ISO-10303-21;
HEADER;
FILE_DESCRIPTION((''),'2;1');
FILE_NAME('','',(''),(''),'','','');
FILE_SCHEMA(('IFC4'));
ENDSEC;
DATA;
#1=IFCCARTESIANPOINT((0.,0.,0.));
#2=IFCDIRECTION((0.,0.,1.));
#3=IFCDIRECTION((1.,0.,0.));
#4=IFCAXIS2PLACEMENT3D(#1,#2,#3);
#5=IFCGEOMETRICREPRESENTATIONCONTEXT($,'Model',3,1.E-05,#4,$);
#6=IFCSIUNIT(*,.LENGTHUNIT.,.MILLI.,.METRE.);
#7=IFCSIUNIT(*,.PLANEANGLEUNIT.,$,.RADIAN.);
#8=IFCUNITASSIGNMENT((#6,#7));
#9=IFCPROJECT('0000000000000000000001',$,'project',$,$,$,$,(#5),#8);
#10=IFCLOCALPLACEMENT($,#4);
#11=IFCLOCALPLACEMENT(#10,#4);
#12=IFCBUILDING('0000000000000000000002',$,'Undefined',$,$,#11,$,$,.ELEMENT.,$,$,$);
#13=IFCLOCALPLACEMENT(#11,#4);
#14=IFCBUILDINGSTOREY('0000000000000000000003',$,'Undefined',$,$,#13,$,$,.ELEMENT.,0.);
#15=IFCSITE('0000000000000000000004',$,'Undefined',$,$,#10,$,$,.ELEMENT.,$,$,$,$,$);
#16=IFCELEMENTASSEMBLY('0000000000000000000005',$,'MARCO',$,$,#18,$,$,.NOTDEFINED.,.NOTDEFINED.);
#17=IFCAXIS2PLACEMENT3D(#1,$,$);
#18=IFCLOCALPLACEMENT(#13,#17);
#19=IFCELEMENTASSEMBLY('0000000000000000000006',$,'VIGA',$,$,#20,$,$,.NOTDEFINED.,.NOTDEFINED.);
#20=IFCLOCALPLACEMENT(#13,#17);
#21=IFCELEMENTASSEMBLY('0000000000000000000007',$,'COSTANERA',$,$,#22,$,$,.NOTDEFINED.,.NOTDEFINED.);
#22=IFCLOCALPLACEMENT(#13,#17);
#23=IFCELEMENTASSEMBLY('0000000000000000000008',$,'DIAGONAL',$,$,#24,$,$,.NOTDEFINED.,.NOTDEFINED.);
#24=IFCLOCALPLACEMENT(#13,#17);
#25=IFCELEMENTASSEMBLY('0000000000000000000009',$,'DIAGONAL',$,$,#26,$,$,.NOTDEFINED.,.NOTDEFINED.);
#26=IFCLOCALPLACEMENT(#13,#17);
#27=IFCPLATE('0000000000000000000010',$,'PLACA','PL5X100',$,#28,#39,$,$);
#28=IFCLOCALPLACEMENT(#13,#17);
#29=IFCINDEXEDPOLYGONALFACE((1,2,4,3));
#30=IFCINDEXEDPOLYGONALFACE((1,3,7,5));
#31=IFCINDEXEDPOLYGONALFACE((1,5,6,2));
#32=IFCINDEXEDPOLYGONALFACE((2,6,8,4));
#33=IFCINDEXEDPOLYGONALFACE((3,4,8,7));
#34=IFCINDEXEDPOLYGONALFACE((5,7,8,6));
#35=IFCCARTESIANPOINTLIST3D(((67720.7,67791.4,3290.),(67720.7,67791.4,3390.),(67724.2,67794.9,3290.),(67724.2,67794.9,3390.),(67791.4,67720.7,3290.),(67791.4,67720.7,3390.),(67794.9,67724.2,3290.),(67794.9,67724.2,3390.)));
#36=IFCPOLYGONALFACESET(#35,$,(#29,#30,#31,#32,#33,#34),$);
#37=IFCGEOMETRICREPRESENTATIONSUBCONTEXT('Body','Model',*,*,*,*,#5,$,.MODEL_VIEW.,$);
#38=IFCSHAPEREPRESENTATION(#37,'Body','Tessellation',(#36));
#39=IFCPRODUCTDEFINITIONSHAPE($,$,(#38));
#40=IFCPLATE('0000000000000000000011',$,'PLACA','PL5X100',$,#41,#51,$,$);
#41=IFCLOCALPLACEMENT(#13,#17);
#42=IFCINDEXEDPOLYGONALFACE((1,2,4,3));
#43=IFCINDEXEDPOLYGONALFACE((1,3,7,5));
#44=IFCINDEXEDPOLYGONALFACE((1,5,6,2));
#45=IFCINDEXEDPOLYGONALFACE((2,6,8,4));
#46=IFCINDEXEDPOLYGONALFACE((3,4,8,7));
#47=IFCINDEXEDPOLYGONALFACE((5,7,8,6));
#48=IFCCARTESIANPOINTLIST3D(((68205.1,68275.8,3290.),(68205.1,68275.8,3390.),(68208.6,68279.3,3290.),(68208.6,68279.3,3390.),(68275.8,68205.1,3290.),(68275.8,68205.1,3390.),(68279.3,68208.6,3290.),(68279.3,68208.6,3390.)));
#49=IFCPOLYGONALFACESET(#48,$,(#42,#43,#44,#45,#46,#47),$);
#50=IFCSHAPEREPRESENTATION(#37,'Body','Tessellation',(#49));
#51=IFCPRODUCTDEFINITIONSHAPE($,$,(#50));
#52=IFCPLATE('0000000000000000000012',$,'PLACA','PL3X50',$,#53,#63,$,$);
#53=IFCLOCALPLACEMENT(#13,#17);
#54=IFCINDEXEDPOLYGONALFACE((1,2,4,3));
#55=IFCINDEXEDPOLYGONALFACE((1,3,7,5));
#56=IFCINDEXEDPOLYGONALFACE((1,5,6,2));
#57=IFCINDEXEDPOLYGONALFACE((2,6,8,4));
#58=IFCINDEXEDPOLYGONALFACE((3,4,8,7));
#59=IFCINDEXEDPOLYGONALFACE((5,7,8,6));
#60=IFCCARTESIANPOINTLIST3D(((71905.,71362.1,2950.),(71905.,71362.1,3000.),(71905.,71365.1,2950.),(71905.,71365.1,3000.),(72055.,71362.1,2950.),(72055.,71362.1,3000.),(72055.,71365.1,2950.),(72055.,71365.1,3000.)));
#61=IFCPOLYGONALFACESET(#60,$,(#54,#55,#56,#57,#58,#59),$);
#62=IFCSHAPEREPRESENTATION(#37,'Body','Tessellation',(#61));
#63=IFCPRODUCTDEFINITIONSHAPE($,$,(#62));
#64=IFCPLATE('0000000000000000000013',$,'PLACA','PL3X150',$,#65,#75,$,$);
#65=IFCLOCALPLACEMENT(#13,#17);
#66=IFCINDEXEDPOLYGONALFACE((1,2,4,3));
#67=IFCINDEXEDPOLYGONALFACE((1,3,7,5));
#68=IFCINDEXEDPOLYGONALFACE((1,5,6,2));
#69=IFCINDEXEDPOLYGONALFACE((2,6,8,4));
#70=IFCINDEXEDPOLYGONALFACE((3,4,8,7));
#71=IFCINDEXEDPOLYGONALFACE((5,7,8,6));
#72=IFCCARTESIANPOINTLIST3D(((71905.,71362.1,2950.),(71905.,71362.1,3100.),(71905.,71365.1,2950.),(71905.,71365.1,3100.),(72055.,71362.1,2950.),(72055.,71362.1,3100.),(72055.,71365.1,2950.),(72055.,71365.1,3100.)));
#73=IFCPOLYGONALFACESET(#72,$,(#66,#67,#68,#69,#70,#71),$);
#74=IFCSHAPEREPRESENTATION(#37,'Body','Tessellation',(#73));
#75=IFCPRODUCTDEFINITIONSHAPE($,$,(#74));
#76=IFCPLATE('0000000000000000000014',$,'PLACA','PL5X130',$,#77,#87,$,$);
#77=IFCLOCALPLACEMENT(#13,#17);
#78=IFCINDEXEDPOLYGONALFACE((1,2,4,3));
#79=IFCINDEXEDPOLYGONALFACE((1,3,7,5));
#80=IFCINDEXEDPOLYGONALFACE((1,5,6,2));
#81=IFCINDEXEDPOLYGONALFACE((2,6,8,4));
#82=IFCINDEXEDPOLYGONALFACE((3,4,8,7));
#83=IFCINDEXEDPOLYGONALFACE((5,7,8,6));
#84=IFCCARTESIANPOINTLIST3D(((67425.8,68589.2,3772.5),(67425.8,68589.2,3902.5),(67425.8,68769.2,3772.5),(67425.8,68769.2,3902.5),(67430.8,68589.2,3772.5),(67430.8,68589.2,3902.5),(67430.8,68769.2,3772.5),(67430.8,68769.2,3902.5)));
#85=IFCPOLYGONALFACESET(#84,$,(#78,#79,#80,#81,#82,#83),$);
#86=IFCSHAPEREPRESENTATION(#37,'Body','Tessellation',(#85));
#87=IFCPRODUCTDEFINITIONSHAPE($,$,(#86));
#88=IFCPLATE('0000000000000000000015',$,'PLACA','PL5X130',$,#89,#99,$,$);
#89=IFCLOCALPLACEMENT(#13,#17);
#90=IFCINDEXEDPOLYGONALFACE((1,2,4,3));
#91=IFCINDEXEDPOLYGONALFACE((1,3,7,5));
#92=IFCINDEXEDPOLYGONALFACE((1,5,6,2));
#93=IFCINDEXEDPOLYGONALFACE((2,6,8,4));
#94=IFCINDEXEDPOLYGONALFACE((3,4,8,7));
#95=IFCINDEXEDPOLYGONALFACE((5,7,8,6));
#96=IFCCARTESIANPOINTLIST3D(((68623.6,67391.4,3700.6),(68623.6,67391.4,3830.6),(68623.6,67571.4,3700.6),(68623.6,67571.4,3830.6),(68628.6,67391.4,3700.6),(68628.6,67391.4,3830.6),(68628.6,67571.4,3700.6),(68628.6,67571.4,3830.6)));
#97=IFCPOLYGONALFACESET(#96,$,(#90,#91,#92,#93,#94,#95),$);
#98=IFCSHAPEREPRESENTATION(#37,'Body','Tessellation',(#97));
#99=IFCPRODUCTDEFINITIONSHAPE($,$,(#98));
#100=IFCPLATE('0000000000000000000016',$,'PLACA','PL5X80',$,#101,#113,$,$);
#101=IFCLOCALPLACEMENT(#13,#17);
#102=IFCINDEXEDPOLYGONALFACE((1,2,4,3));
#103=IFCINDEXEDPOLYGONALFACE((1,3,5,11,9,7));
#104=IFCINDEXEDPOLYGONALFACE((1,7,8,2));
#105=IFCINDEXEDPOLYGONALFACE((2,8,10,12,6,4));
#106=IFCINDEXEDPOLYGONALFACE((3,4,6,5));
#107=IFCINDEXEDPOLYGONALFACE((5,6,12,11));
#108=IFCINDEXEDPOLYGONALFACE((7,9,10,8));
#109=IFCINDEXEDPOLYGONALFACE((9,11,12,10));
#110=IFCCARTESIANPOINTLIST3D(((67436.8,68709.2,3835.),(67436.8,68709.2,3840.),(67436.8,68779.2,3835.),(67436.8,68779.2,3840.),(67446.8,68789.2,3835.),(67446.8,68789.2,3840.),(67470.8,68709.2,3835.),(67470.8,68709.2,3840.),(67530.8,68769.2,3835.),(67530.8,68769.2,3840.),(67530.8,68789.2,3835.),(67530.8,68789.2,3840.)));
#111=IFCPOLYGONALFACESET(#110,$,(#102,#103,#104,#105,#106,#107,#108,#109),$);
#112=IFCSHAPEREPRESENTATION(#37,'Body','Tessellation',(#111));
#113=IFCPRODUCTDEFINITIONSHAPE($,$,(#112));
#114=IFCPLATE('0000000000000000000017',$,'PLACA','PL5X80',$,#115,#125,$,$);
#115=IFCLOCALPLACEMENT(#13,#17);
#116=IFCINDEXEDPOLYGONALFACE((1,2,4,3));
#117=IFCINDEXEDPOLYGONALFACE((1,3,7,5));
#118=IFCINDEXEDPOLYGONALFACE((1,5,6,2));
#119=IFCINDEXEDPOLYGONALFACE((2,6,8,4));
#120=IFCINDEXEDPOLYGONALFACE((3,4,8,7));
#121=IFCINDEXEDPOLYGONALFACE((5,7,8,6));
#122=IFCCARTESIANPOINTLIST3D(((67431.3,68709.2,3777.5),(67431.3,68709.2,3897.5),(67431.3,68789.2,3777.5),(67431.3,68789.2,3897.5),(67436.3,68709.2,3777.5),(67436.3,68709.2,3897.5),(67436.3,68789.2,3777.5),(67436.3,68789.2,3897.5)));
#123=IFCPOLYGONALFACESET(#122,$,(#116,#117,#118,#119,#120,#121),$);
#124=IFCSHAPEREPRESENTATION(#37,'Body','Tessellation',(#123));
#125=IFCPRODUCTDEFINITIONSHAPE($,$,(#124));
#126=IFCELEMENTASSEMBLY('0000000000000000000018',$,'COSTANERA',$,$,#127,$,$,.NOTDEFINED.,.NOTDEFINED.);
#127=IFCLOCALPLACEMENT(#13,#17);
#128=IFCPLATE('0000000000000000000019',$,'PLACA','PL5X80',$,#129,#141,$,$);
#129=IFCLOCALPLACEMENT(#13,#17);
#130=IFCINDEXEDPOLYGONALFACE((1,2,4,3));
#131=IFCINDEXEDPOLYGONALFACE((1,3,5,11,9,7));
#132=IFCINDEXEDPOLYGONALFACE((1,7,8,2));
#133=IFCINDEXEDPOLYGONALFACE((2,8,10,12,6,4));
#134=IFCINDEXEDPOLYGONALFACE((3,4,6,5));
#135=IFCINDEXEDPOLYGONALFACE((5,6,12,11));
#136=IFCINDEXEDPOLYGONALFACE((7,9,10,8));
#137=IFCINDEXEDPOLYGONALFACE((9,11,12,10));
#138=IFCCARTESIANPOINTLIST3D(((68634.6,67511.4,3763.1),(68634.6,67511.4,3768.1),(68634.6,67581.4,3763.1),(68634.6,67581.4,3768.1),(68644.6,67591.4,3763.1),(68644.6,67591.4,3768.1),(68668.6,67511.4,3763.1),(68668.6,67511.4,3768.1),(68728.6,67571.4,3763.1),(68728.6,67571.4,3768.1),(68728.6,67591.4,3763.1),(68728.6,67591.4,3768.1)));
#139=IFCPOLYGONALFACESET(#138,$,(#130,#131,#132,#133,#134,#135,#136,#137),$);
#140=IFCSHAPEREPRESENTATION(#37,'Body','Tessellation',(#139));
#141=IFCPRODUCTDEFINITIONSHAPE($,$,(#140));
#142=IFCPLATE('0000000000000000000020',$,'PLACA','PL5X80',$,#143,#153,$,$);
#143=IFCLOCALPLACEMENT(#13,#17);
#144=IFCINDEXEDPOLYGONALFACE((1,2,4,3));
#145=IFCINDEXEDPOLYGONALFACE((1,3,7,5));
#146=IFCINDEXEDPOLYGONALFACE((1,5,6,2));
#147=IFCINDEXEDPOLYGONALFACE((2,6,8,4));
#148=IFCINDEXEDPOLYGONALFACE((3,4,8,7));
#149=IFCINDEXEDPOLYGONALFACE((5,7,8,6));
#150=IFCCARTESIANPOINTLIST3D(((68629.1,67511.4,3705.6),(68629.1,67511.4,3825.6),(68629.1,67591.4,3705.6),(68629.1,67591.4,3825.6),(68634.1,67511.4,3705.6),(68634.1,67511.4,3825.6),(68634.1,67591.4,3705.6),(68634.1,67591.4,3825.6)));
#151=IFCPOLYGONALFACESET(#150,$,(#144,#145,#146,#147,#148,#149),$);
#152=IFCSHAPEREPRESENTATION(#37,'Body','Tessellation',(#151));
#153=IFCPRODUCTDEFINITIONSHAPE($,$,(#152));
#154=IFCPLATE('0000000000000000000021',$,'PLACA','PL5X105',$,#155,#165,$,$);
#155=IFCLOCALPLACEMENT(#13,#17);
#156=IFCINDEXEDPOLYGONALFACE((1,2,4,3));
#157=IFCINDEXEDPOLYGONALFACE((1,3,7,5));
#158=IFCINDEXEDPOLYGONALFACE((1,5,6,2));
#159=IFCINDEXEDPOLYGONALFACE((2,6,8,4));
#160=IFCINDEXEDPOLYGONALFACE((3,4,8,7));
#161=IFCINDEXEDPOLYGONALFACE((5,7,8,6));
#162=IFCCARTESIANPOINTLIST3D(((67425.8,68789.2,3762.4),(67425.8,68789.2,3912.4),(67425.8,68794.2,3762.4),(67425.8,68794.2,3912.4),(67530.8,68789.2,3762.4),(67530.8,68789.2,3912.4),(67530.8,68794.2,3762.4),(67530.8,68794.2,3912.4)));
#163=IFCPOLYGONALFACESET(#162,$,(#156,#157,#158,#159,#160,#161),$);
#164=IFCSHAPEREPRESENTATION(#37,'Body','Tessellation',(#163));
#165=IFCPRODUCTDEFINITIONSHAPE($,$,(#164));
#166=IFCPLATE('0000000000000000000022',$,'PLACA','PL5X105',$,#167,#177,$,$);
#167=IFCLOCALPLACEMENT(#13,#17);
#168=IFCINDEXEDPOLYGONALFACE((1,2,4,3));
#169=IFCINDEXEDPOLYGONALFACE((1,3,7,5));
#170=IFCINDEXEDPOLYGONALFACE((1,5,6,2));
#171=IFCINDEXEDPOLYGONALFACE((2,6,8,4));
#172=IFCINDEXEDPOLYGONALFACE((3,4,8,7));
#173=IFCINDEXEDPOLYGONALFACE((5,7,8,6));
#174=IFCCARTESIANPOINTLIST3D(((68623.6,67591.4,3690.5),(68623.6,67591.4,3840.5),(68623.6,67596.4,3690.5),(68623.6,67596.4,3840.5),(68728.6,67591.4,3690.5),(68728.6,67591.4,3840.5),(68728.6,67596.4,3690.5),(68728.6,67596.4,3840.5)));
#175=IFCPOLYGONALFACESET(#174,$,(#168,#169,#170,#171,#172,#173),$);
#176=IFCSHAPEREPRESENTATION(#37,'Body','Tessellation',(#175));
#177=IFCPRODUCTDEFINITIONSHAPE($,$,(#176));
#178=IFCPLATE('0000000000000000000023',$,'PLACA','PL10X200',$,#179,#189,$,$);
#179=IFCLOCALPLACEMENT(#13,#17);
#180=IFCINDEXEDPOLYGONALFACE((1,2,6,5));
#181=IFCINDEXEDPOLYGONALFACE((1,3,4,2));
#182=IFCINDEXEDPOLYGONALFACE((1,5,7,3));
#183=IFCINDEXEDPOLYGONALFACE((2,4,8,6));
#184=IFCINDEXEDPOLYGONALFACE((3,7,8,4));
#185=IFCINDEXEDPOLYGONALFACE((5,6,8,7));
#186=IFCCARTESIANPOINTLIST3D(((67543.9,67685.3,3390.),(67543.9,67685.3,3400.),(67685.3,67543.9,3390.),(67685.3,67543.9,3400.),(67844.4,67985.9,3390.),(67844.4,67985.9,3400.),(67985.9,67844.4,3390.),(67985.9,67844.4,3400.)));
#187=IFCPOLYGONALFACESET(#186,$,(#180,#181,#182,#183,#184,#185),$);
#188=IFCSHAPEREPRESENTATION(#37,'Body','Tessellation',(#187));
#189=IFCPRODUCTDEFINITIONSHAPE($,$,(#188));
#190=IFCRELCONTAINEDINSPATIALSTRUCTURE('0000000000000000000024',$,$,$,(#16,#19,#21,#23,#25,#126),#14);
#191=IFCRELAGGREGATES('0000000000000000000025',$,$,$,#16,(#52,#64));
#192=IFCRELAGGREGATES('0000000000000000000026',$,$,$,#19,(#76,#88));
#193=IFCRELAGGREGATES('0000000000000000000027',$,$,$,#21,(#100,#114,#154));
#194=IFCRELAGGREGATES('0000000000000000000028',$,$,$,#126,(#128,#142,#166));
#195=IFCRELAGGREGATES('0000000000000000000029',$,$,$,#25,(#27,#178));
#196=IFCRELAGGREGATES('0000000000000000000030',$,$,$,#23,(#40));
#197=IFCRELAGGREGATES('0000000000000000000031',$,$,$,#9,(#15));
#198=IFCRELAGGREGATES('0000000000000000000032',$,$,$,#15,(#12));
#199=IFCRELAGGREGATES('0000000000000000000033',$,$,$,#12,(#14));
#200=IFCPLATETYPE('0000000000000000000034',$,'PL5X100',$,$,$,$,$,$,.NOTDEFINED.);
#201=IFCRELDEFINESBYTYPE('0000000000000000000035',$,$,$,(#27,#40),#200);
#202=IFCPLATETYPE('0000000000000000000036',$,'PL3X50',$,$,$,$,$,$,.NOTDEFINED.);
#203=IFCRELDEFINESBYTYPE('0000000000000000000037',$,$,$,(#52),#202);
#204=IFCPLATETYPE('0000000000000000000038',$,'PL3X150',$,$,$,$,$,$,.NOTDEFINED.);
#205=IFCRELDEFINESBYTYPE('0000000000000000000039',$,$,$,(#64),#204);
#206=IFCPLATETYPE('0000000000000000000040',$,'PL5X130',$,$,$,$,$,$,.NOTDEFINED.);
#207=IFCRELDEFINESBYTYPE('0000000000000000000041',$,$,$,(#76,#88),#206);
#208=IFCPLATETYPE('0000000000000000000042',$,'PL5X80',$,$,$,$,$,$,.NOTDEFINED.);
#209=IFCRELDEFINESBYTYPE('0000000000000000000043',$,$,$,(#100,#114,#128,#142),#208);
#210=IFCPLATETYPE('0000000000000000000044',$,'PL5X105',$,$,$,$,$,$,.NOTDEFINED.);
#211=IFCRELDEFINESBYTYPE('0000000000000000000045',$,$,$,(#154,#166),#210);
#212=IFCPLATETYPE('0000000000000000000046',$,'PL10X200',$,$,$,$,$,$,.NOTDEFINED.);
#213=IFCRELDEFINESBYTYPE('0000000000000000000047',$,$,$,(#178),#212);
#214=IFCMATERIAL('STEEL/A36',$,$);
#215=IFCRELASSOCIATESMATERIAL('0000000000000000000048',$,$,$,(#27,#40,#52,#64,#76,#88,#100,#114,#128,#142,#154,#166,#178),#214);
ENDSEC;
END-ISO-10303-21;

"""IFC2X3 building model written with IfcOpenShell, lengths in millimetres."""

from ifc_helpers import new_model, si_unit, frame, origin_with_axes, place, context, subcontext, project, spatial, polyline, outline, extrude, material, type_object, element, aggregate, save


model = new_model("IFC2X3")

# Units and contexts
model_context = context("Model", 3, precision=1e-05, world=origin_with_axes())
body_context = subcontext(model_context, "Body", "Model", "MODEL_VIEW")
ifc_project = project(units=[si_unit("LENGTHUNIT", "METRE", prefix="MILLI"), si_unit("PLANEANGLEUNIT", "RADIAN")], contexts=[model_context])

# Site, building, storey
site_placement = place(None, origin_with_axes())
site = spatial("IfcSite", under=ifc_project, at=site_placement, Name="Undefined", CompositionType="ELEMENT")
building_placement = place(site_placement, origin_with_axes())
building = spatial("IfcBuilding", under=site, at=building_placement, Name="Undefined", CompositionType="ELEMENT")
storey_placement = place(building_placement, origin_with_axes())
storey = spatial("IfcBuildingStorey", under=building, at=storey_placement, Name="Undefined", CompositionType="ELEMENT", Elevation=0.0)

# Element assemblies
assembly_1_placement = place(storey_placement, origin_with_axes())
assembly_1 = element("IfcElementAssembly", 1, at=assembly_1_placement, inside=storey, Name="MARCO", AssemblyPlace="NOTDEFINED", PredefinedType="NOTDEFINED")
ifc_material_1 = material(Name="STEEL/A36")
assembly_2_placement = place(storey_placement, origin_with_axes())
assembly_2 = element("IfcElementAssembly", 2, at=assembly_2_placement, inside=storey, Name="VIGA", AssemblyPlace="NOTDEFINED", PredefinedType="NOTDEFINED")
assembly_3_placement = place(storey_placement, origin_with_axes())
assembly_3 = element("IfcElementAssembly", 3, at=assembly_3_placement, inside=storey, Name="COSTANERA", AssemblyPlace="NOTDEFINED", PredefinedType="NOTDEFINED")
assembly_4_placement = place(storey_placement, origin_with_axes())
assembly_4 = element("IfcElementAssembly", 4, at=assembly_4_placement, inside=storey, Name="DIAGONAL", AssemblyPlace="NOTDEFINED", PredefinedType="NOTDEFINED")

# Element assembly
assembly_5_placement = place(storey_placement, origin_with_axes())
assembly_5 = element("IfcElementAssembly", 5, at=assembly_5_placement, inside=storey, Name="DIAGONAL", AssemblyPlace="NOTDEFINED", PredefinedType="NOTDEFINED")

# Plates
plate_type_1 = type_object("IfcPlateType", Name="PL5X100", PredefinedType="NOTDEFINED")
plate_1_placement = place(assembly_5_placement, frame((67757.8, 67757.8, 3390.0), z_axis=(-0.707107, -0.707107, 0.0), x_axis=(0.0, 0.0, -1.0)))
plate_1 = element("IfcPlate", 6, at=plate_1_placement, type_object=plate_type_1, material=ifc_material_1, Name="PLACA", Description="PL5X100", context=body_context, shape_type="SweptSolid", body=[
    extrude(outline(polyline([(0.0, -50.0), (0.0, 50.0), (100.0, 50.0), (100.0, -50.0), (0.0, -50.0)])), frame((0.0, 0.0, -2.5), z_axis=(0.0, 0.0, 1.0), x_axis=(1.0, 0.0, 0.0)), (0.0, 0.0, 1.0), 5.0),
])
plate_2_placement = place(assembly_4_placement, frame((68242.2, 68242.2, 3390.0), z_axis=(0.707107, 0.707107, 0.0), x_axis=(0.0, 0.0, -1.0)))
plate_2 = element("IfcPlate", 7, at=plate_2_placement, type_object=plate_type_1, material=ifc_material_1, Name="PLACA", Description="PL5X100", context=body_context, shape_type="SweptSolid", body=[
    extrude(outline(polyline([(0.0, -50.0), (0.0, 50.0), (100.0, 50.0), (100.0, -50.0), (0.0, -50.0)])), frame((0.0, 0.0, -2.5), z_axis=(0.0, 0.0, 1.0), x_axis=(1.0, 0.0, 0.0)), (0.0, 0.0, 1.0), 5.0),
])
plate_type_2 = type_object("IfcPlateType", Name="PL3X50", PredefinedType="NOTDEFINED")
plate_3_placement = place(assembly_1_placement, frame((72055.0, 71363.6, 3000.0), z_axis=(0.0, 1.0, 0.0), x_axis=(0.0, 0.0, -1.0)))
plate_3 = element("IfcPlate", 8, at=plate_3_placement, type_object=plate_type_2, material=ifc_material_1, Name="PLACA", Description="PL3X50", context=body_context, shape_type="SweptSolid", body=[
    extrude(outline(polyline([(0.0, 0.0), (50.0, 0.0), (50.0, 150.0), (0.0, 150.0), (0.0, 0.0)])), frame((0.0, 0.0, -1.5), z_axis=(0.0, 0.0, 1.0), x_axis=(1.0, 0.0, 0.0)), (0.0, 0.0, 1.0), 3.0),
])
plate_type_3 = type_object("IfcPlateType", Name="PL3X150", PredefinedType="NOTDEFINED")
plate_4_placement = place(assembly_1_placement, frame((71905.0, 71363.6, 2950.0), z_axis=(0.0, -1.0, 0.0), x_axis=(1.0, 0.0, 0.0)))
plate_4 = element("IfcPlate", 9, at=plate_4_placement, type_object=plate_type_3, material=ifc_material_1, Name="PLACA", Description="PL3X150", context=body_context, shape_type="SweptSolid", body=[
    extrude(outline(polyline([(0.0, 0.0), (150.0, 0.0), (150.0, 150.0), (0.0, 150.0), (0.0, 0.0)])), frame((0.0, 0.0, -1.5), z_axis=(0.0, 0.0, 1.0), x_axis=(1.0, 0.0, 0.0)), (0.0, 0.0, 1.0), 3.0),
])
aggregate(assembly_1, [plate_3, plate_4])
plate_type_4 = type_object("IfcPlateType", Name="PL5X130", PredefinedType="NOTDEFINED")
plate_5_placement = place(assembly_2_placement, frame((67428.3, 68769.2, 3902.5), z_axis=(1.0, 0.0, 0.0), x_axis=(0.0, -1.0, 0.0)))
plate_5 = element("IfcPlate", 10, at=plate_5_placement, type_object=plate_type_4, material=ifc_material_1, Name="PLACA", Description="PL5X130", context=body_context, shape_type="SweptSolid", body=[
    extrude(outline(polyline([(0.0, 0.0), (180.0, 0.0), (180.0, 130.0), (0.0, 130.0), (0.0, 0.0)])), frame((0.0, 0.0, -2.5), z_axis=(0.0, 0.0, 1.0), x_axis=(1.0, 0.0, 0.0)), (0.0, 0.0, 1.0), 5.0),
])
plate_6_placement = place(assembly_2_placement, frame((68626.1, 67571.4, 3830.6), z_axis=(1.0, 0.0, 0.0), x_axis=(0.0, -1.0, 0.0)))
plate_6 = element("IfcPlate", 11, at=plate_6_placement, type_object=plate_type_4, material=ifc_material_1, Name="PLACA", Description="PL5X130", context=body_context, shape_type="SweptSolid", body=[
    extrude(outline(polyline([(0.0, 0.0), (180.0, 0.0), (180.0, 130.0), (0.0, 130.0), (0.0, 0.0)])), frame((0.0, 0.0, -2.5), z_axis=(0.0, 0.0, 1.0), x_axis=(1.0, 0.0, 0.0)), (0.0, 0.0, 1.0), 5.0),
])
plate_type_5 = type_object("IfcPlateType", Name="PL5X80", PredefinedType="NOTDEFINED")
plate_7_placement = place(assembly_3_placement, frame((67436.8, 68709.2, 3837.5), z_axis=(0.0, 0.0, -1.0), x_axis=(0.0, 1.0, 0.0)))
plate_7 = element("IfcPlate", 12, at=plate_7_placement, type_object=plate_type_5, material=ifc_material_1, Name="PLACA", Description="PL5X80", context=body_context, shape_type="SweptSolid", body=[
    extrude(outline(polyline([(0.0, 0.0), (70.0, 0.0), (80.0, 10.0), (80.0, 94.0), (60.0, 94.0), (0.0, 34.0), (0.0, 0.0)])), frame((0.0, 0.0, -2.5), z_axis=(0.0, 0.0, 1.0), x_axis=(1.0, 0.0, 0.0)), (0.0, 0.0, 1.0), 5.0),
])
plate_8_placement = place(assembly_3_placement, frame((67433.8, 68709.2, 3897.5), z_axis=(-1.0, 0.0, 0.0), x_axis=(0.0, 1.0, 0.0)))
plate_8 = element("IfcPlate", 13, at=plate_8_placement, type_object=plate_type_5, material=ifc_material_1, Name="PLACA", Description="PL5X80", context=body_context, shape_type="SweptSolid", body=[
    extrude(outline(polyline([(0.0, 0.0), (80.0, 0.0), (80.0, 120.0), (0.0, 120.0), (0.0, 0.0)])), frame((0.0, 0.0, -2.5), z_axis=(0.0, 0.0, 1.0), x_axis=(1.0, 0.0, 0.0)), (0.0, 0.0, 1.0), 5.0),
])

# Element assembly, plates
assembly_6_placement = place(storey_placement, origin_with_axes())
assembly_6 = element("IfcElementAssembly", 14, at=assembly_6_placement, inside=storey, Name="COSTANERA", AssemblyPlace="NOTDEFINED", PredefinedType="NOTDEFINED")
plate_9_placement = place(assembly_6_placement, frame((68634.6, 67511.4, 3765.6), z_axis=(0.0, 0.0, -1.0), x_axis=(0.0, 1.0, 0.0)))
plate_9 = element("IfcPlate", 15, at=plate_9_placement, type_object=plate_type_5, material=ifc_material_1, Name="PLACA", Description="PL5X80", context=body_context, shape_type="SweptSolid", body=[
    extrude(outline(polyline([(0.0, 0.0), (70.0, 0.0), (80.0, 10.0), (80.0, 94.0), (60.0, 94.0), (0.0, 34.0), (0.0, 0.0)])), frame((0.0, 0.0, -2.5), z_axis=(0.0, 0.0, 1.0), x_axis=(1.0, 0.0, 0.0)), (0.0, 0.0, 1.0), 5.0),
])
plate_10_placement = place(assembly_6_placement, frame((68631.6, 67511.4, 3825.6), z_axis=(-1.0, 0.0, 0.0), x_axis=(0.0, 1.0, 0.0)))
plate_10 = element("IfcPlate", 16, at=plate_10_placement, type_object=plate_type_5, material=ifc_material_1, Name="PLACA", Description="PL5X80", context=body_context, shape_type="SweptSolid", body=[
    extrude(outline(polyline([(0.0, 0.0), (80.0, 0.0), (80.0, 120.0), (0.0, 120.0), (0.0, 0.0)])), frame((0.0, 0.0, -2.5), z_axis=(0.0, 0.0, 1.0), x_axis=(1.0, 0.0, 0.0)), (0.0, 0.0, 1.0), 5.0),
])

# Plates
plate_type_6 = type_object("IfcPlateType", Name="PL5X105", PredefinedType="NOTDEFINED")
plate_11_placement = place(assembly_3_placement, frame((67530.8, 68791.7, 3762.4), z_axis=(0.0, 1.0, 0.0), x_axis=(-1.0, 0.0, 0.0)))
plate_11 = element("IfcPlate", 17, at=plate_11_placement, type_object=plate_type_6, material=ifc_material_1, Name="PLACA", Description="PL5X105", context=body_context, shape_type="SweptSolid", body=[
    extrude(outline(polyline([(0.0, 0.0), (105.0, 0.0), (105.0, 150.0), (0.0, 150.0), (0.0, 0.0)])), frame((0.0, 0.0, -2.5), z_axis=(0.0, 0.0, 1.0), x_axis=(1.0, 0.0, 0.0)), (0.0, 0.0, 1.0), 5.0),
])
plate_12_placement = place(assembly_6_placement, frame((68728.6, 67593.9, 3690.5), z_axis=(0.0, 1.0, 0.0), x_axis=(-1.0, 0.0, 0.0)))
plate_12 = element("IfcPlate", 18, at=plate_12_placement, type_object=plate_type_6, material=ifc_material_1, Name="PLACA", Description="PL5X105", context=body_context, shape_type="SweptSolid", body=[
    extrude(outline(polyline([(0.0, 0.0), (105.0, 0.0), (105.0, 150.0), (0.0, 150.0), (0.0, 0.0)])), frame((0.0, 0.0, -2.5), z_axis=(0.0, 0.0, 1.0), x_axis=(1.0, 0.0, 0.0)), (0.0, 0.0, 1.0), 5.0),
])
plate_type_7 = type_object("IfcPlateType", Name="PL10X200", PredefinedType="NOTDEFINED")
plate_13_placement = place(assembly_5_placement, frame((67915.2, 67915.1, 3395.0), z_axis=(0.0, 0.0, 1.0), x_axis=(-0.707107, -0.707107, 0.0)))
plate_13 = element("IfcPlate", 19, at=plate_13_placement, type_object=plate_type_7, material=ifc_material_1, Name="PLACA", Description="PL10X200", context=body_context, shape_type="SweptSolid", body=[
    extrude(outline(polyline([(0.0, -100.0), (0.0, 100.0), (425.0, 100.0), (425.0, -100.0), (0.0, -100.0)])), frame((0.0, 0.0, -5.0), z_axis=(0.0, 0.0, 1.0), x_axis=(1.0, 0.0, 0.0)), (0.0, 0.0, 1.0), 10.0),
])
aggregate(assembly_2, [plate_5, plate_6])

aggregate(assembly_3, [plate_7, plate_8, plate_11])
aggregate(assembly_6, [plate_9, plate_10, plate_12])
aggregate(assembly_5, [plate_1, plate_13])
aggregate(assembly_4, [plate_2])

save(model, "model.ifc")
